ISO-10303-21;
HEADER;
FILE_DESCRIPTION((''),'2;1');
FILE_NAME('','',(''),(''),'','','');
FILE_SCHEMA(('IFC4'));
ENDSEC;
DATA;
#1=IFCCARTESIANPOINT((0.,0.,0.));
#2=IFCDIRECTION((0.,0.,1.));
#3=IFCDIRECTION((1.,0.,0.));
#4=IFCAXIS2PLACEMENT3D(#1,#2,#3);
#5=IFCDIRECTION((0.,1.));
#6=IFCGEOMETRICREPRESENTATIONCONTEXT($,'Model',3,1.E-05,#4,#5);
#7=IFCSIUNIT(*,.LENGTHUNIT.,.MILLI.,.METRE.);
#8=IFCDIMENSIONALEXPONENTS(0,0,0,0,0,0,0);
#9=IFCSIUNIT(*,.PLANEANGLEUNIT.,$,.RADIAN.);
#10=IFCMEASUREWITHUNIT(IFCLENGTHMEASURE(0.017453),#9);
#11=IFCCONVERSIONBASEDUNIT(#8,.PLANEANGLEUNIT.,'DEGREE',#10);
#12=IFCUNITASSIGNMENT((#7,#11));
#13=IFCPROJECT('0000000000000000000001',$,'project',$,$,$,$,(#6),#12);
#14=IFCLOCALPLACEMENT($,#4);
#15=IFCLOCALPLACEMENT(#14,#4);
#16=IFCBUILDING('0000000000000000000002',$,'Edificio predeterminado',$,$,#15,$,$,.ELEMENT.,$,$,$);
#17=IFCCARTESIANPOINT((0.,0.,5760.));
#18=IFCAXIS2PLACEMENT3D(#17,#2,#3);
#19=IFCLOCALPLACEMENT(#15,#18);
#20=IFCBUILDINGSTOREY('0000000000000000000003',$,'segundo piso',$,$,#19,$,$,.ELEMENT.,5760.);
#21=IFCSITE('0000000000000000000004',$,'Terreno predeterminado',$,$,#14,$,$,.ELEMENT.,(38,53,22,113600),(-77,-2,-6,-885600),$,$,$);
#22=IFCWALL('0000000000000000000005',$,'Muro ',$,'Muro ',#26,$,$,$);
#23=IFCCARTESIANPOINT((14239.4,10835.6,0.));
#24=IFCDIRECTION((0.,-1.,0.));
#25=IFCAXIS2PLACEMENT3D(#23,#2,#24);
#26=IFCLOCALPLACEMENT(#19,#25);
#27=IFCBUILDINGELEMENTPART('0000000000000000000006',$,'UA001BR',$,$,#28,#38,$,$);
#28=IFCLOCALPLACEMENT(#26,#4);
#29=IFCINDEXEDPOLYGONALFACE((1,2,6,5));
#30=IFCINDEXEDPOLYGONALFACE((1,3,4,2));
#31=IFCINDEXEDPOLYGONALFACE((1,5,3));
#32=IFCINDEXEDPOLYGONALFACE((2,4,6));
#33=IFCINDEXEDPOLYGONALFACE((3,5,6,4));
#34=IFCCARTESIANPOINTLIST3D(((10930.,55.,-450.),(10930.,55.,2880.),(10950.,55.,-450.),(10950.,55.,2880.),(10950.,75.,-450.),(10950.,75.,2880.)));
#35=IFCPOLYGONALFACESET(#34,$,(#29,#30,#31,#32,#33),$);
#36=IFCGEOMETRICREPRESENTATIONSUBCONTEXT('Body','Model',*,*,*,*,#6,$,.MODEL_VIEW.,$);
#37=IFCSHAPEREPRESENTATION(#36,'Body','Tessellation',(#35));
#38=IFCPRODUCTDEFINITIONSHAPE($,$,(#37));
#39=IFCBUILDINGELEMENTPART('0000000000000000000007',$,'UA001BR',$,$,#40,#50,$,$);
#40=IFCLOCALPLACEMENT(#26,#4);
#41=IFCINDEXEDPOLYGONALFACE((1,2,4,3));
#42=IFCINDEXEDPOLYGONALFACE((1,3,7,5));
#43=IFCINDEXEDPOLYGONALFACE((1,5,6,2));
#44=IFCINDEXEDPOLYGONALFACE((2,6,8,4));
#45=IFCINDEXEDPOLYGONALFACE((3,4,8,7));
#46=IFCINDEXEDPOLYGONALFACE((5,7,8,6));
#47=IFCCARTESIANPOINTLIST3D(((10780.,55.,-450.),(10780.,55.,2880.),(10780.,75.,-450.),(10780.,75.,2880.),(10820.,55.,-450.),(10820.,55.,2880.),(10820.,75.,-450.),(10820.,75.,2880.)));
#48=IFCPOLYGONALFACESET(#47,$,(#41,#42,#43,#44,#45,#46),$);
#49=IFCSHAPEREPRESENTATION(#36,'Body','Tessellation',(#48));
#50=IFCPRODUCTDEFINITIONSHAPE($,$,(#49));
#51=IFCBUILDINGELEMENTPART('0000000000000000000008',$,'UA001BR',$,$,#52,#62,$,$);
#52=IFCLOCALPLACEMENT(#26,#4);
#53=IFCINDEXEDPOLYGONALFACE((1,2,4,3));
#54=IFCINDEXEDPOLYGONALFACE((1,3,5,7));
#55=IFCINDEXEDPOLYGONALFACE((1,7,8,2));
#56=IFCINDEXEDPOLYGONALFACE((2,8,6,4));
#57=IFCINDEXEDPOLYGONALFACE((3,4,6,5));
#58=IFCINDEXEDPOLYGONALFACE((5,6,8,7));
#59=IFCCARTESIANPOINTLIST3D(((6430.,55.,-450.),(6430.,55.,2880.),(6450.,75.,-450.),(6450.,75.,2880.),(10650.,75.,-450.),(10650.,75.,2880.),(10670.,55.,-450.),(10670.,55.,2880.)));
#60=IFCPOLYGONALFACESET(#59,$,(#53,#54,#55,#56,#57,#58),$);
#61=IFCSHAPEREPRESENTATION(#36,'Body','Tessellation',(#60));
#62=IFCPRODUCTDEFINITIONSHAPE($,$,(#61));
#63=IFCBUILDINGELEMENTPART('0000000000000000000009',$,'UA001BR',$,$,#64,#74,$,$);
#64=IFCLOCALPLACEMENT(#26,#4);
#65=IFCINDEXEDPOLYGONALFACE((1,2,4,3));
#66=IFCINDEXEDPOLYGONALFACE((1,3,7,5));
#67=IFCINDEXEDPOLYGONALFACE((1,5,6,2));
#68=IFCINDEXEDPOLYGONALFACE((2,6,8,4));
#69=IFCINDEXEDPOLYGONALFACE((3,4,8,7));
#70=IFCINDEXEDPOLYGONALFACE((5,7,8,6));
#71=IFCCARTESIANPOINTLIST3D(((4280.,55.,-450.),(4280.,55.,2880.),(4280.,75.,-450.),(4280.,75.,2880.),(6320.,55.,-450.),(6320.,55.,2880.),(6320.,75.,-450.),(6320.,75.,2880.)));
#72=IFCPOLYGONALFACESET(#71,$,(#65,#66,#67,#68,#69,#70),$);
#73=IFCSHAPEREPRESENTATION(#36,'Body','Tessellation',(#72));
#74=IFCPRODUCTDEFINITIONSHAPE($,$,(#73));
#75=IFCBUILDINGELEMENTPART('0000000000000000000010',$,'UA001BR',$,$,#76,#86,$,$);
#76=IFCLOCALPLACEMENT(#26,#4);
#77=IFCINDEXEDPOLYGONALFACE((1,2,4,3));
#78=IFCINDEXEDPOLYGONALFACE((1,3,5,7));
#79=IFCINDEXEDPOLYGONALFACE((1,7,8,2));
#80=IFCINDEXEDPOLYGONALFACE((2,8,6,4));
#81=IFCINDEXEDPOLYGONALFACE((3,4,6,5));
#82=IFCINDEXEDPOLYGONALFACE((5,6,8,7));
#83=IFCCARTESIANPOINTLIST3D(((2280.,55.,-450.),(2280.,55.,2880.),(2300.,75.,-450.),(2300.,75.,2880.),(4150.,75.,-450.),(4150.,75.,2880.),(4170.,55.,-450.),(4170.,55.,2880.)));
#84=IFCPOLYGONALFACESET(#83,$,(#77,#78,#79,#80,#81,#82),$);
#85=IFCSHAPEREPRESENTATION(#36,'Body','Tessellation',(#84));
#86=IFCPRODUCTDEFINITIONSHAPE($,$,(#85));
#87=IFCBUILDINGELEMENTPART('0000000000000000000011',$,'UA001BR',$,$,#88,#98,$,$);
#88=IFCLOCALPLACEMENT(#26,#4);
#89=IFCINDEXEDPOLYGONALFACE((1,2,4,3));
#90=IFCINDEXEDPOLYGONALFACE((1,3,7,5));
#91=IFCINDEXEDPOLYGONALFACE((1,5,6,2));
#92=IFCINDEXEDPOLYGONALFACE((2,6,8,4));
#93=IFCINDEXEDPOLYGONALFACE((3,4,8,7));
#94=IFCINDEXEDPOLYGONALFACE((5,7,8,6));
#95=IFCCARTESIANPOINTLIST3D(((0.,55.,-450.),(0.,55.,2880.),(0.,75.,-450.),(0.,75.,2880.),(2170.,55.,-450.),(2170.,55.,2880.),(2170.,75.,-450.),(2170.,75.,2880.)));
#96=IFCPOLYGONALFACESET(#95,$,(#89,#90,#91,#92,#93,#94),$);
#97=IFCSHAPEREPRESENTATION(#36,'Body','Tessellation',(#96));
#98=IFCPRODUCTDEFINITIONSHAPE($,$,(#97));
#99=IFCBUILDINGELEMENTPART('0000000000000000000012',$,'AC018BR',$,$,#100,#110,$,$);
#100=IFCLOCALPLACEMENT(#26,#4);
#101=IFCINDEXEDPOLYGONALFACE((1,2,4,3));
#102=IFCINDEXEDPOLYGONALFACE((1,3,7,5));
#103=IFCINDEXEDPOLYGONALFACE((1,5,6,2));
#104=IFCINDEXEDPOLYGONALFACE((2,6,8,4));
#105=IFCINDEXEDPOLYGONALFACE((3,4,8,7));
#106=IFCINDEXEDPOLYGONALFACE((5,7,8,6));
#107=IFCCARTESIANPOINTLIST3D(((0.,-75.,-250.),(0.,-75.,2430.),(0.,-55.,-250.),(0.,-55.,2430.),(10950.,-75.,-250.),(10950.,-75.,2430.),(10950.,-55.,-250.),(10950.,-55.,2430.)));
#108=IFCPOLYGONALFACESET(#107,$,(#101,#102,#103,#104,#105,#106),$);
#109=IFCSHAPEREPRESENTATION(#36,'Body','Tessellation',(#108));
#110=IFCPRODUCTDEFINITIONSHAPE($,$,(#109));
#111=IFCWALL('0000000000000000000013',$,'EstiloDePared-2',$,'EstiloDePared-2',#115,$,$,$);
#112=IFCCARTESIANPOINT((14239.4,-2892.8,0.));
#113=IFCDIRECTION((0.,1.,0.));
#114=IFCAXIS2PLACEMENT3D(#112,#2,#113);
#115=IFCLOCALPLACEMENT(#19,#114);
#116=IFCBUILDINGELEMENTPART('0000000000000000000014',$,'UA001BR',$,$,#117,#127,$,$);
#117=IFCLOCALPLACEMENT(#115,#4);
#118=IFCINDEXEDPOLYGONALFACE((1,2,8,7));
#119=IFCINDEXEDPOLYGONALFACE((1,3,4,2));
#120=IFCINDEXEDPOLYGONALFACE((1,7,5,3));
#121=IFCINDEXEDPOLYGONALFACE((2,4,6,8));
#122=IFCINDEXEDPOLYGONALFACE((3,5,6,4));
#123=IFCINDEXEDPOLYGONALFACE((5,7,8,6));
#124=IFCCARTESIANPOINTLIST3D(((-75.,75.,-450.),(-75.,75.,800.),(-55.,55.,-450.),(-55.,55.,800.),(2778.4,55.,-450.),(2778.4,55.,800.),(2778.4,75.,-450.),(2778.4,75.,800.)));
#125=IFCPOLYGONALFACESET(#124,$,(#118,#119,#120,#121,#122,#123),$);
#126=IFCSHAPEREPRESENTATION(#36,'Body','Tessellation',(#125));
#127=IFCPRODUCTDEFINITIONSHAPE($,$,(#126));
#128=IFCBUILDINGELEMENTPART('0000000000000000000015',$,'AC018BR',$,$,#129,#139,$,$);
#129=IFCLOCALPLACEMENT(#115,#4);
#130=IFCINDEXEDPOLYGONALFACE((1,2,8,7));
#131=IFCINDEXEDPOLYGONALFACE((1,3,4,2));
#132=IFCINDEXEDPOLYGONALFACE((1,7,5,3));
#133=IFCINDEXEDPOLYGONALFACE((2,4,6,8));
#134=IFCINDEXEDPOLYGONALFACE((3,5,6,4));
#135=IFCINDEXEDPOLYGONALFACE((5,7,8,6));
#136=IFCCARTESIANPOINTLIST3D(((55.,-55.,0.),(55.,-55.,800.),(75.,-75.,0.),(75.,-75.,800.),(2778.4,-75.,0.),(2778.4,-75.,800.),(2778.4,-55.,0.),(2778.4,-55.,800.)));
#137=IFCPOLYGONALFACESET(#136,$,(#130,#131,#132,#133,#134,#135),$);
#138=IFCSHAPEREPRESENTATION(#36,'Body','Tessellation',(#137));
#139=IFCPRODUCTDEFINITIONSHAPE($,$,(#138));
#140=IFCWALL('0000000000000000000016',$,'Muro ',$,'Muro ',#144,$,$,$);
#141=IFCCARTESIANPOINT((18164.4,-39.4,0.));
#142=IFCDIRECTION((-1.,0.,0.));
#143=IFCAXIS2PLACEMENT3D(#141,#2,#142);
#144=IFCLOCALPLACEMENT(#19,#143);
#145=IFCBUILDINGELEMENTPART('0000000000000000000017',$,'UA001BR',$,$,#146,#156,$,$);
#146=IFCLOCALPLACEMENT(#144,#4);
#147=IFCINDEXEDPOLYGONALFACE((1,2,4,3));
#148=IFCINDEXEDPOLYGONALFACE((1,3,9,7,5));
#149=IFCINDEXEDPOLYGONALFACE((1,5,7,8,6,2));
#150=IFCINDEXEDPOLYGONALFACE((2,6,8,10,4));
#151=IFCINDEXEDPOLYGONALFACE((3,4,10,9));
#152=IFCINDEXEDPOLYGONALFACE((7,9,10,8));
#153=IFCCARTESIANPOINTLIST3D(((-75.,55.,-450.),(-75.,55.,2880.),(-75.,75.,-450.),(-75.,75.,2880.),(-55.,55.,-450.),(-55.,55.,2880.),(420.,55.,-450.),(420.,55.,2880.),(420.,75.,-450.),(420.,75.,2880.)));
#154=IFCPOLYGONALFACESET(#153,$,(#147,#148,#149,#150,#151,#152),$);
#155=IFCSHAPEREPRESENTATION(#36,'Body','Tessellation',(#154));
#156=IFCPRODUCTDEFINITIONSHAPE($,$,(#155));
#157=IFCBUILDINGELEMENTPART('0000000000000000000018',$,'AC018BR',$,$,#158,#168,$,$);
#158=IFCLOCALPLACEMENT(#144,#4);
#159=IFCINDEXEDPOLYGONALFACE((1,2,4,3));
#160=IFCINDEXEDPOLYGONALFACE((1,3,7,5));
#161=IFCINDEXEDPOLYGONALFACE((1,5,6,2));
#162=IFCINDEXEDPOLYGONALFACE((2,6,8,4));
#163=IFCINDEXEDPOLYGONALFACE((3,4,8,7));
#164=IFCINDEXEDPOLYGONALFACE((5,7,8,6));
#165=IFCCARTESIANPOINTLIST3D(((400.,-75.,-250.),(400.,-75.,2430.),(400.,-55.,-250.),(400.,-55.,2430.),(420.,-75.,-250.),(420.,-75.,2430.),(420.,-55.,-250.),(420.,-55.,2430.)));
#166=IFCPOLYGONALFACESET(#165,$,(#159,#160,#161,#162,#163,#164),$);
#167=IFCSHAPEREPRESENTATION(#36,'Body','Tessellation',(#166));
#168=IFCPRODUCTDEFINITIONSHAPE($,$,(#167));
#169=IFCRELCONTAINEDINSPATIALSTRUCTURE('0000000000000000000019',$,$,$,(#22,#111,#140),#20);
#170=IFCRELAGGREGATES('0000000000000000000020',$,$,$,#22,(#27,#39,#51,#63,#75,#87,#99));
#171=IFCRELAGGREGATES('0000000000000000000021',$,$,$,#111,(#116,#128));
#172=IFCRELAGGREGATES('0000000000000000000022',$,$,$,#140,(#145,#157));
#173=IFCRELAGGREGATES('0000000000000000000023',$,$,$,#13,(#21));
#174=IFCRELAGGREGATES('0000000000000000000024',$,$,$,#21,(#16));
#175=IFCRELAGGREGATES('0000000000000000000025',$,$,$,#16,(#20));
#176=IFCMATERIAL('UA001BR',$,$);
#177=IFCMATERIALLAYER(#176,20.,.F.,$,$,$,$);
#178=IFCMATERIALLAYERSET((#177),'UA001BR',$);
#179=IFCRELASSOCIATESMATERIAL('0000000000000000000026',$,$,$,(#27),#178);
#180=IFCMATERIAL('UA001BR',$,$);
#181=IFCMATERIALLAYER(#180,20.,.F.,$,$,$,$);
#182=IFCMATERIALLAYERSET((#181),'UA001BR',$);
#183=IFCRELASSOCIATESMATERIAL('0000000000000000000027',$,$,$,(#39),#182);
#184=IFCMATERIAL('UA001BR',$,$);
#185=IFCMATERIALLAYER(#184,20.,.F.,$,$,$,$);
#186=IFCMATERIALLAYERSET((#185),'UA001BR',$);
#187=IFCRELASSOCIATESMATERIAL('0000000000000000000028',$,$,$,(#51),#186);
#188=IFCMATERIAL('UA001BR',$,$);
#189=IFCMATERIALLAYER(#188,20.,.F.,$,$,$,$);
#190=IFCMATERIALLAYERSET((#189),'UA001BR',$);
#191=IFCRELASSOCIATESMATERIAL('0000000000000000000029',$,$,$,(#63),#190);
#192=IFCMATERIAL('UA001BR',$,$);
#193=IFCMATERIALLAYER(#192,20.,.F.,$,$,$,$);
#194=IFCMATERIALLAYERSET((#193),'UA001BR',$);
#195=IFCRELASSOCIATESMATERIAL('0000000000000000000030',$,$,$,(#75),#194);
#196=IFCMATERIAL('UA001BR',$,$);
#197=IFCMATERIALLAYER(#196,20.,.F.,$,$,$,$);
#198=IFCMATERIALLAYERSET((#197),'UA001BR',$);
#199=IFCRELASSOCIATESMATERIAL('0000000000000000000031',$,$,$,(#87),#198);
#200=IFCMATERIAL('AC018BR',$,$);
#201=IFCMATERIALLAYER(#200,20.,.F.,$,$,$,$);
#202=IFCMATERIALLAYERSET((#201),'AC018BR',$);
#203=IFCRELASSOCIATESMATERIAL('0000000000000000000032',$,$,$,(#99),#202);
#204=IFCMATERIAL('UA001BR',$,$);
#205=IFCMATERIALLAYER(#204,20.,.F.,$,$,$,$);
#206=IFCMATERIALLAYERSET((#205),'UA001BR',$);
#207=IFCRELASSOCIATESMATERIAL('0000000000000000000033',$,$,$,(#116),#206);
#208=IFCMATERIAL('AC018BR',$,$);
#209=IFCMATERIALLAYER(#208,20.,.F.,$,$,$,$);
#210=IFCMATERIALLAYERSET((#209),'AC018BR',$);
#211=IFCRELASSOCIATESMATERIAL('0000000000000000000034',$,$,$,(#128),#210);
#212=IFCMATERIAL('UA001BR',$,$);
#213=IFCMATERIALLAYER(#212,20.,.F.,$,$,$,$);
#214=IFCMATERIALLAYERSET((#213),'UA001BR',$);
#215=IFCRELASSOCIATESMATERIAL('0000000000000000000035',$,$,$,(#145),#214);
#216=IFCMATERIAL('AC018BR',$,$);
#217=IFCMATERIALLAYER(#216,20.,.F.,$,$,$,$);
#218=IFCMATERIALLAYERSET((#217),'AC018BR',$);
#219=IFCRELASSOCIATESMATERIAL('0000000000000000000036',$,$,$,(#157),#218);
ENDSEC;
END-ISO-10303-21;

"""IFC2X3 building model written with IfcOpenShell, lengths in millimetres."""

from ifc_helpers import new_model, entity, si_unit, converted_unit, direction, frame, origin_with_axes, place, context, subcontext, project, spatial, polyline, outline, extrude, material, layer, layer_set, layer_usage, element, aggregate, save


model = new_model("IFC2X3")

# Units and contexts
model_context = context("Model", 3, precision=1e-05, world=origin_with_axes(), true_north=direction((0.0, 1.0)))
body_context = subcontext(model_context, "Body", "Model", "MODEL_VIEW")
ifc_project = project(units=[si_unit("LENGTHUNIT", "METRE", prefix="MILLI"), converted_unit("PLANEANGLEUNIT", "DEGREE", entity("IfcLengthMeasure", 0.017453), si_unit("PLANEANGLEUNIT", "RADIAN"), dimensions=[0, 0, 0, 0, 0, 0, 0])], contexts=[model_context])

# Site, building, storey
site_placement = place(None, origin_with_axes())
site = spatial("IfcSite", under=ifc_project, at=site_placement, Name="Terreno predeterminado", CompositionType="ELEMENT", RefLatitude=(38, 53, 22, 113600), RefLongitude=(-77, -2, -6, -885600))
building_placement = place(site_placement, origin_with_axes())
building = spatial("IfcBuilding", under=site, at=building_placement, Name="Edificio predeterminado", CompositionType="ELEMENT")
storey_placement = place(building_placement, frame((0.0, 0.0, 5760.0), z_axis=(0.0, 0.0, 1.0), x_axis=(1.0, 0.0, 0.0)))
storey = spatial("IfcBuildingStorey", under=building, at=storey_placement, Name="segundo piso", CompositionType="ELEMENT", Elevation=5760.0)

# Walls, building element parts
wall_1_placement = place(storey_placement, frame((14239.4, 10835.6, 0.0), z_axis=(0.0, 0.0, 1.0), x_axis=(0.0, -1.0, 0.0)))
wall_1 = element("IfcWall", 1, at=wall_1_placement, inside=storey, Name="Muro ", ObjectType="Muro ")
ifc_material_1 = material(Name="UA001BR")
ifc_layer_1 = layer(ifc_material_1, 20.0, ventilated=False)
ifc_layer_set_1 = layer_set([ifc_layer_1], Name="UA001BR")
ifc_layer_usage_1 = layer_usage(ifc_layer_set_1, "AXIS2", "NEGATIVE", -75.0)
building_element_part_1_placement = place(wall_1_placement, origin_with_axes())
building_element_part_1 = element("IfcBuildingElementPart", 2, at=building_element_part_1_placement, material=ifc_layer_usage_1, Name="UA001BR", context=body_context, shape_type="SweptSolid", body=[
    extrude(outline(polyline([(10950.0, 75.0), (10950.0, 55.0), (10930.0, 55.0), (10950.0, 75.0)])), frame((0.0, 0.0, -450.0), z_axis=(0.0, 0.0, 1.0), x_axis=(1.0, 0.0, 0.0)), (0.0, 0.0, 1.0), 3330.0),
])
ifc_material_2 = material(Name="UA001BR")
ifc_layer_2 = layer(ifc_material_2, 20.0, ventilated=False)
ifc_layer_set_2 = layer_set([ifc_layer_2], Name="UA001BR")
ifc_layer_usage_2 = layer_usage(ifc_layer_set_2, "AXIS2", "NEGATIVE", -75.0)
building_element_part_2_placement = place(wall_1_placement, origin_with_axes())
building_element_part_2 = element("IfcBuildingElementPart", 3, at=building_element_part_2_placement, material=ifc_layer_usage_2, Name="UA001BR", context=body_context, shape_type="SweptSolid", body=[
    extrude(outline(polyline([(10820.0, 75.0), (10820.0, 55.0), (10780.0, 55.0), (10780.0, 75.0), (10820.0, 75.0)])), frame((0.0, 0.0, -450.0), z_axis=(0.0, 0.0, 1.0), x_axis=(1.0, 0.0, 0.0)), (0.0, 0.0, 1.0), 3330.0),
])
ifc_material_3 = material(Name="UA001BR")
ifc_layer_3 = layer(ifc_material_3, 20.0, ventilated=False)
ifc_layer_set_3 = layer_set([ifc_layer_3], Name="UA001BR")
ifc_layer_usage_3 = layer_usage(ifc_layer_set_3, "AXIS2", "NEGATIVE", -75.0)
building_element_part_3_placement = place(wall_1_placement, origin_with_axes())
building_element_part_3 = element("IfcBuildingElementPart", 4, at=building_element_part_3_placement, material=ifc_layer_usage_3, Name="UA001BR", context=body_context, shape_type="SweptSolid", body=[
    extrude(outline(polyline([(10650.0, 75.0), (10670.0, 55.0), (6430.0, 55.0), (6450.0, 75.0), (10650.0, 75.0)])), frame((0.0, 0.0, -450.0), z_axis=(0.0, 0.0, 1.0), x_axis=(1.0, 0.0, 0.0)), (0.0, 0.0, 1.0), 3330.0),
])
ifc_material_4 = material(Name="UA001BR")
ifc_layer_4 = layer(ifc_material_4, 20.0, ventilated=False)
ifc_layer_set_4 = layer_set([ifc_layer_4], Name="UA001BR")
ifc_layer_usage_4 = layer_usage(ifc_layer_set_4, "AXIS2", "NEGATIVE", -75.0)
building_element_part_4_placement = place(wall_1_placement, origin_with_axes())
building_element_part_4 = element("IfcBuildingElementPart", 5, at=building_element_part_4_placement, material=ifc_layer_usage_4, Name="UA001BR", context=body_context, shape_type="SweptSolid", body=[
    extrude(outline(polyline([(4280.0, 75.0), (6320.0, 75.0), (6320.0, 55.0), (4280.0, 55.0), (4280.0, 75.0)])), frame((0.0, 0.0, -450.0), z_axis=(0.0, 0.0, 1.0), x_axis=(1.0, 0.0, 0.0)), (0.0, 0.0, 1.0), 3330.0),
])
ifc_material_5 = material(Name="UA001BR")
ifc_layer_5 = layer(ifc_material_5, 20.0, ventilated=False)
ifc_layer_set_5 = layer_set([ifc_layer_5], Name="UA001BR")
ifc_layer_usage_5 = layer_usage(ifc_layer_set_5, "AXIS2", "NEGATIVE", -75.0)
building_element_part_5_placement = place(wall_1_placement, origin_with_axes())
building_element_part_5 = element("IfcBuildingElementPart", 6, at=building_element_part_5_placement, material=ifc_layer_usage_5, Name="UA001BR", context=body_context, shape_type="SweptSolid", body=[
    extrude(outline(polyline([(4150.0, 75.0), (4170.0, 55.0), (2280.0, 55.0), (2300.0, 75.0), (4150.0, 75.0)])), frame((0.0, 0.0, -450.0), z_axis=(0.0, 0.0, 1.0), x_axis=(1.0, 0.0, 0.0)), (0.0, 0.0, 1.0), 3330.0),
])
ifc_material_6 = material(Name="UA001BR")
ifc_layer_6 = layer(ifc_material_6, 20.0, ventilated=False)
ifc_layer_set_6 = layer_set([ifc_layer_6], Name="UA001BR")
ifc_layer_usage_6 = layer_usage(ifc_layer_set_6, "AXIS2", "NEGATIVE", -75.0)
building_element_part_6_placement = place(wall_1_placement, origin_with_axes())
building_element_part_6 = element("IfcBuildingElementPart", 7, at=building_element_part_6_placement, material=ifc_layer_usage_6, Name="UA001BR", context=body_context, shape_type="SweptSolid", body=[
    extrude(outline(polyline([(2170.0, 75.0), (2170.0, 55.0), (0.0, 55.0), (0.0, 75.0), (2170.0, 75.0)])), frame((0.0, 0.0, -450.0), z_axis=(0.0, 0.0, 1.0), x_axis=(1.0, 0.0, 0.0)), (0.0, 0.0, 1.0), 3330.0),
])
ifc_material_7 = material(Name="AC018BR")
ifc_layer_7 = layer(ifc_material_7, 20.0, ventilated=False)
ifc_layer_set_7 = layer_set([ifc_layer_7], Name="AC018BR")
ifc_layer_usage_7 = layer_usage(ifc_layer_set_7, "AXIS2", "NEGATIVE", 55.0)
building_element_part_7_placement = place(wall_1_placement, origin_with_axes())
building_element_part_7 = element("IfcBuildingElementPart", 8, at=building_element_part_7_placement, material=ifc_layer_usage_7, Name="AC018BR", context=body_context, shape_type="SweptSolid", body=[
    extrude(outline(polyline([(10950.0, -55.0), (10950.0, -75.0), (0.0, -75.0), (0.0, -55.0), (10950.0, -55.0)])), frame((0.0, 0.0, -250.0), z_axis=(0.0, 0.0, 1.0), x_axis=(1.0, 0.0, 0.0)), (0.0, 0.0, 1.0), 2680.0),
])
aggregate(wall_1, [building_element_part_1, building_element_part_2, building_element_part_3, building_element_part_4, building_element_part_5, building_element_part_6, building_element_part_7])
wall_2_placement = place(storey_placement, frame((14239.4, -2892.8, 0.0), z_axis=(0.0, 0.0, 1.0), x_axis=(0.0, 1.0, 0.0)))
wall_2 = element("IfcWall", 9, at=wall_2_placement, inside=storey, Name="EstiloDePared-2", ObjectType="EstiloDePared-2")
ifc_material_8 = material(Name="UA001BR")
ifc_layer_8 = layer(ifc_material_8, 20.0, ventilated=False)
ifc_layer_set_8 = layer_set([ifc_layer_8], Name="UA001BR")
ifc_layer_usage_8 = layer_usage(ifc_layer_set_8, "AXIS2", "NEGATIVE", -75.0)
building_element_part_8_placement = place(wall_2_placement, origin_with_axes())
building_element_part_8 = element("IfcBuildingElementPart", 10, at=building_element_part_8_placement, material=ifc_layer_usage_8, Name="UA001BR", context=body_context, shape_type="SweptSolid", body=[
    extrude(outline(polyline([(2778.4, 75.0), (2778.4, 55.0), (-55.0, 55.0), (-75.0, 75.0), (2778.4, 75.0)])), frame((0.0, 0.0, -450.0), z_axis=(0.0, 0.0, 1.0), x_axis=(1.0, 0.0, 0.0)), (0.0, 0.0, 1.0), 1250.0),
])
ifc_material_9 = material(Name="AC018BR")
ifc_layer_9 = layer(ifc_material_9, 20.0, ventilated=False)
ifc_layer_set_9 = layer_set([ifc_layer_9], Name="AC018BR")
ifc_layer_usage_9 = layer_usage(ifc_layer_set_9, "AXIS2", "NEGATIVE", 55.0)
building_element_part_9_placement = place(wall_2_placement, origin_with_axes())
building_element_part_9 = element("IfcBuildingElementPart", 11, at=building_element_part_9_placement, material=ifc_layer_usage_9, Name="AC018BR", context=body_context, shape_type="SweptSolid", body=[
    extrude(outline(polyline([(2778.4, -55.0), (2778.4, -75.0), (75.0, -75.0), (55.0, -55.0), (2778.4, -55.0)])), origin_with_axes(), (0.0, 0.0, 1.0), 800.0),
])
aggregate(wall_2, [building_element_part_8, building_element_part_9])
wall_3_placement = place(storey_placement, frame((18164.4, -39.4, 0.0), z_axis=(0.0, 0.0, 1.0), x_axis=(-1.0, 0.0, 0.0)))
wall_3 = element("IfcWall", 12, at=wall_3_placement, inside=storey, Name="Muro ", ObjectType="Muro ")
ifc_material_10 = material(Name="UA001BR")
ifc_layer_10 = layer(ifc_material_10, 20.0, ventilated=False)
ifc_layer_set_10 = layer_set([ifc_layer_10], Name="UA001BR")
ifc_layer_usage_10 = layer_usage(ifc_layer_set_10, "AXIS2", "NEGATIVE", -75.0)
building_element_part_10_placement = place(wall_3_placement, origin_with_axes())
building_element_part_10 = element("IfcBuildingElementPart", 13, at=building_element_part_10_placement, material=ifc_layer_usage_10, Name="UA001BR", context=body_context, shape_type="SweptSolid", body=[
    extrude(outline(polyline([(420.0, 75.0), (420.0, 55.0), (-55.0, 55.0), (-75.0, 55.0), (-75.0, 75.0), (420.0, 75.0)])), frame((0.0, 0.0, -450.0), z_axis=(0.0, 0.0, 1.0), x_axis=(1.0, 0.0, 0.0)), (0.0, 0.0, 1.0), 3330.0),
])
ifc_material_11 = material(Name="AC018BR")
ifc_layer_11 = layer(ifc_material_11, 20.0, ventilated=False)
ifc_layer_set_11 = layer_set([ifc_layer_11], Name="AC018BR")
ifc_layer_usage_11 = layer_usage(ifc_layer_set_11, "AXIS2", "NEGATIVE", 55.0)
building_element_part_11_placement = place(wall_3_placement, origin_with_axes())
building_element_part_11 = element("IfcBuildingElementPart", 14, at=building_element_part_11_placement, material=ifc_layer_usage_11, Name="AC018BR", context=body_context, shape_type="SweptSolid", body=[
    extrude(outline(polyline([(420.0, -55.0), (420.0, -75.0), (400.0, -75.0), (400.0, -55.0), (420.0, -55.0)])), frame((0.0, 0.0, -250.0), z_axis=(0.0, 0.0, 1.0), x_axis=(1.0, 0.0, 0.0)), (0.0, 0.0, 1.0), 2680.0),
])
aggregate(wall_3, [building_element_part_10, building_element_part_11])

save(model, "model.ifc")
